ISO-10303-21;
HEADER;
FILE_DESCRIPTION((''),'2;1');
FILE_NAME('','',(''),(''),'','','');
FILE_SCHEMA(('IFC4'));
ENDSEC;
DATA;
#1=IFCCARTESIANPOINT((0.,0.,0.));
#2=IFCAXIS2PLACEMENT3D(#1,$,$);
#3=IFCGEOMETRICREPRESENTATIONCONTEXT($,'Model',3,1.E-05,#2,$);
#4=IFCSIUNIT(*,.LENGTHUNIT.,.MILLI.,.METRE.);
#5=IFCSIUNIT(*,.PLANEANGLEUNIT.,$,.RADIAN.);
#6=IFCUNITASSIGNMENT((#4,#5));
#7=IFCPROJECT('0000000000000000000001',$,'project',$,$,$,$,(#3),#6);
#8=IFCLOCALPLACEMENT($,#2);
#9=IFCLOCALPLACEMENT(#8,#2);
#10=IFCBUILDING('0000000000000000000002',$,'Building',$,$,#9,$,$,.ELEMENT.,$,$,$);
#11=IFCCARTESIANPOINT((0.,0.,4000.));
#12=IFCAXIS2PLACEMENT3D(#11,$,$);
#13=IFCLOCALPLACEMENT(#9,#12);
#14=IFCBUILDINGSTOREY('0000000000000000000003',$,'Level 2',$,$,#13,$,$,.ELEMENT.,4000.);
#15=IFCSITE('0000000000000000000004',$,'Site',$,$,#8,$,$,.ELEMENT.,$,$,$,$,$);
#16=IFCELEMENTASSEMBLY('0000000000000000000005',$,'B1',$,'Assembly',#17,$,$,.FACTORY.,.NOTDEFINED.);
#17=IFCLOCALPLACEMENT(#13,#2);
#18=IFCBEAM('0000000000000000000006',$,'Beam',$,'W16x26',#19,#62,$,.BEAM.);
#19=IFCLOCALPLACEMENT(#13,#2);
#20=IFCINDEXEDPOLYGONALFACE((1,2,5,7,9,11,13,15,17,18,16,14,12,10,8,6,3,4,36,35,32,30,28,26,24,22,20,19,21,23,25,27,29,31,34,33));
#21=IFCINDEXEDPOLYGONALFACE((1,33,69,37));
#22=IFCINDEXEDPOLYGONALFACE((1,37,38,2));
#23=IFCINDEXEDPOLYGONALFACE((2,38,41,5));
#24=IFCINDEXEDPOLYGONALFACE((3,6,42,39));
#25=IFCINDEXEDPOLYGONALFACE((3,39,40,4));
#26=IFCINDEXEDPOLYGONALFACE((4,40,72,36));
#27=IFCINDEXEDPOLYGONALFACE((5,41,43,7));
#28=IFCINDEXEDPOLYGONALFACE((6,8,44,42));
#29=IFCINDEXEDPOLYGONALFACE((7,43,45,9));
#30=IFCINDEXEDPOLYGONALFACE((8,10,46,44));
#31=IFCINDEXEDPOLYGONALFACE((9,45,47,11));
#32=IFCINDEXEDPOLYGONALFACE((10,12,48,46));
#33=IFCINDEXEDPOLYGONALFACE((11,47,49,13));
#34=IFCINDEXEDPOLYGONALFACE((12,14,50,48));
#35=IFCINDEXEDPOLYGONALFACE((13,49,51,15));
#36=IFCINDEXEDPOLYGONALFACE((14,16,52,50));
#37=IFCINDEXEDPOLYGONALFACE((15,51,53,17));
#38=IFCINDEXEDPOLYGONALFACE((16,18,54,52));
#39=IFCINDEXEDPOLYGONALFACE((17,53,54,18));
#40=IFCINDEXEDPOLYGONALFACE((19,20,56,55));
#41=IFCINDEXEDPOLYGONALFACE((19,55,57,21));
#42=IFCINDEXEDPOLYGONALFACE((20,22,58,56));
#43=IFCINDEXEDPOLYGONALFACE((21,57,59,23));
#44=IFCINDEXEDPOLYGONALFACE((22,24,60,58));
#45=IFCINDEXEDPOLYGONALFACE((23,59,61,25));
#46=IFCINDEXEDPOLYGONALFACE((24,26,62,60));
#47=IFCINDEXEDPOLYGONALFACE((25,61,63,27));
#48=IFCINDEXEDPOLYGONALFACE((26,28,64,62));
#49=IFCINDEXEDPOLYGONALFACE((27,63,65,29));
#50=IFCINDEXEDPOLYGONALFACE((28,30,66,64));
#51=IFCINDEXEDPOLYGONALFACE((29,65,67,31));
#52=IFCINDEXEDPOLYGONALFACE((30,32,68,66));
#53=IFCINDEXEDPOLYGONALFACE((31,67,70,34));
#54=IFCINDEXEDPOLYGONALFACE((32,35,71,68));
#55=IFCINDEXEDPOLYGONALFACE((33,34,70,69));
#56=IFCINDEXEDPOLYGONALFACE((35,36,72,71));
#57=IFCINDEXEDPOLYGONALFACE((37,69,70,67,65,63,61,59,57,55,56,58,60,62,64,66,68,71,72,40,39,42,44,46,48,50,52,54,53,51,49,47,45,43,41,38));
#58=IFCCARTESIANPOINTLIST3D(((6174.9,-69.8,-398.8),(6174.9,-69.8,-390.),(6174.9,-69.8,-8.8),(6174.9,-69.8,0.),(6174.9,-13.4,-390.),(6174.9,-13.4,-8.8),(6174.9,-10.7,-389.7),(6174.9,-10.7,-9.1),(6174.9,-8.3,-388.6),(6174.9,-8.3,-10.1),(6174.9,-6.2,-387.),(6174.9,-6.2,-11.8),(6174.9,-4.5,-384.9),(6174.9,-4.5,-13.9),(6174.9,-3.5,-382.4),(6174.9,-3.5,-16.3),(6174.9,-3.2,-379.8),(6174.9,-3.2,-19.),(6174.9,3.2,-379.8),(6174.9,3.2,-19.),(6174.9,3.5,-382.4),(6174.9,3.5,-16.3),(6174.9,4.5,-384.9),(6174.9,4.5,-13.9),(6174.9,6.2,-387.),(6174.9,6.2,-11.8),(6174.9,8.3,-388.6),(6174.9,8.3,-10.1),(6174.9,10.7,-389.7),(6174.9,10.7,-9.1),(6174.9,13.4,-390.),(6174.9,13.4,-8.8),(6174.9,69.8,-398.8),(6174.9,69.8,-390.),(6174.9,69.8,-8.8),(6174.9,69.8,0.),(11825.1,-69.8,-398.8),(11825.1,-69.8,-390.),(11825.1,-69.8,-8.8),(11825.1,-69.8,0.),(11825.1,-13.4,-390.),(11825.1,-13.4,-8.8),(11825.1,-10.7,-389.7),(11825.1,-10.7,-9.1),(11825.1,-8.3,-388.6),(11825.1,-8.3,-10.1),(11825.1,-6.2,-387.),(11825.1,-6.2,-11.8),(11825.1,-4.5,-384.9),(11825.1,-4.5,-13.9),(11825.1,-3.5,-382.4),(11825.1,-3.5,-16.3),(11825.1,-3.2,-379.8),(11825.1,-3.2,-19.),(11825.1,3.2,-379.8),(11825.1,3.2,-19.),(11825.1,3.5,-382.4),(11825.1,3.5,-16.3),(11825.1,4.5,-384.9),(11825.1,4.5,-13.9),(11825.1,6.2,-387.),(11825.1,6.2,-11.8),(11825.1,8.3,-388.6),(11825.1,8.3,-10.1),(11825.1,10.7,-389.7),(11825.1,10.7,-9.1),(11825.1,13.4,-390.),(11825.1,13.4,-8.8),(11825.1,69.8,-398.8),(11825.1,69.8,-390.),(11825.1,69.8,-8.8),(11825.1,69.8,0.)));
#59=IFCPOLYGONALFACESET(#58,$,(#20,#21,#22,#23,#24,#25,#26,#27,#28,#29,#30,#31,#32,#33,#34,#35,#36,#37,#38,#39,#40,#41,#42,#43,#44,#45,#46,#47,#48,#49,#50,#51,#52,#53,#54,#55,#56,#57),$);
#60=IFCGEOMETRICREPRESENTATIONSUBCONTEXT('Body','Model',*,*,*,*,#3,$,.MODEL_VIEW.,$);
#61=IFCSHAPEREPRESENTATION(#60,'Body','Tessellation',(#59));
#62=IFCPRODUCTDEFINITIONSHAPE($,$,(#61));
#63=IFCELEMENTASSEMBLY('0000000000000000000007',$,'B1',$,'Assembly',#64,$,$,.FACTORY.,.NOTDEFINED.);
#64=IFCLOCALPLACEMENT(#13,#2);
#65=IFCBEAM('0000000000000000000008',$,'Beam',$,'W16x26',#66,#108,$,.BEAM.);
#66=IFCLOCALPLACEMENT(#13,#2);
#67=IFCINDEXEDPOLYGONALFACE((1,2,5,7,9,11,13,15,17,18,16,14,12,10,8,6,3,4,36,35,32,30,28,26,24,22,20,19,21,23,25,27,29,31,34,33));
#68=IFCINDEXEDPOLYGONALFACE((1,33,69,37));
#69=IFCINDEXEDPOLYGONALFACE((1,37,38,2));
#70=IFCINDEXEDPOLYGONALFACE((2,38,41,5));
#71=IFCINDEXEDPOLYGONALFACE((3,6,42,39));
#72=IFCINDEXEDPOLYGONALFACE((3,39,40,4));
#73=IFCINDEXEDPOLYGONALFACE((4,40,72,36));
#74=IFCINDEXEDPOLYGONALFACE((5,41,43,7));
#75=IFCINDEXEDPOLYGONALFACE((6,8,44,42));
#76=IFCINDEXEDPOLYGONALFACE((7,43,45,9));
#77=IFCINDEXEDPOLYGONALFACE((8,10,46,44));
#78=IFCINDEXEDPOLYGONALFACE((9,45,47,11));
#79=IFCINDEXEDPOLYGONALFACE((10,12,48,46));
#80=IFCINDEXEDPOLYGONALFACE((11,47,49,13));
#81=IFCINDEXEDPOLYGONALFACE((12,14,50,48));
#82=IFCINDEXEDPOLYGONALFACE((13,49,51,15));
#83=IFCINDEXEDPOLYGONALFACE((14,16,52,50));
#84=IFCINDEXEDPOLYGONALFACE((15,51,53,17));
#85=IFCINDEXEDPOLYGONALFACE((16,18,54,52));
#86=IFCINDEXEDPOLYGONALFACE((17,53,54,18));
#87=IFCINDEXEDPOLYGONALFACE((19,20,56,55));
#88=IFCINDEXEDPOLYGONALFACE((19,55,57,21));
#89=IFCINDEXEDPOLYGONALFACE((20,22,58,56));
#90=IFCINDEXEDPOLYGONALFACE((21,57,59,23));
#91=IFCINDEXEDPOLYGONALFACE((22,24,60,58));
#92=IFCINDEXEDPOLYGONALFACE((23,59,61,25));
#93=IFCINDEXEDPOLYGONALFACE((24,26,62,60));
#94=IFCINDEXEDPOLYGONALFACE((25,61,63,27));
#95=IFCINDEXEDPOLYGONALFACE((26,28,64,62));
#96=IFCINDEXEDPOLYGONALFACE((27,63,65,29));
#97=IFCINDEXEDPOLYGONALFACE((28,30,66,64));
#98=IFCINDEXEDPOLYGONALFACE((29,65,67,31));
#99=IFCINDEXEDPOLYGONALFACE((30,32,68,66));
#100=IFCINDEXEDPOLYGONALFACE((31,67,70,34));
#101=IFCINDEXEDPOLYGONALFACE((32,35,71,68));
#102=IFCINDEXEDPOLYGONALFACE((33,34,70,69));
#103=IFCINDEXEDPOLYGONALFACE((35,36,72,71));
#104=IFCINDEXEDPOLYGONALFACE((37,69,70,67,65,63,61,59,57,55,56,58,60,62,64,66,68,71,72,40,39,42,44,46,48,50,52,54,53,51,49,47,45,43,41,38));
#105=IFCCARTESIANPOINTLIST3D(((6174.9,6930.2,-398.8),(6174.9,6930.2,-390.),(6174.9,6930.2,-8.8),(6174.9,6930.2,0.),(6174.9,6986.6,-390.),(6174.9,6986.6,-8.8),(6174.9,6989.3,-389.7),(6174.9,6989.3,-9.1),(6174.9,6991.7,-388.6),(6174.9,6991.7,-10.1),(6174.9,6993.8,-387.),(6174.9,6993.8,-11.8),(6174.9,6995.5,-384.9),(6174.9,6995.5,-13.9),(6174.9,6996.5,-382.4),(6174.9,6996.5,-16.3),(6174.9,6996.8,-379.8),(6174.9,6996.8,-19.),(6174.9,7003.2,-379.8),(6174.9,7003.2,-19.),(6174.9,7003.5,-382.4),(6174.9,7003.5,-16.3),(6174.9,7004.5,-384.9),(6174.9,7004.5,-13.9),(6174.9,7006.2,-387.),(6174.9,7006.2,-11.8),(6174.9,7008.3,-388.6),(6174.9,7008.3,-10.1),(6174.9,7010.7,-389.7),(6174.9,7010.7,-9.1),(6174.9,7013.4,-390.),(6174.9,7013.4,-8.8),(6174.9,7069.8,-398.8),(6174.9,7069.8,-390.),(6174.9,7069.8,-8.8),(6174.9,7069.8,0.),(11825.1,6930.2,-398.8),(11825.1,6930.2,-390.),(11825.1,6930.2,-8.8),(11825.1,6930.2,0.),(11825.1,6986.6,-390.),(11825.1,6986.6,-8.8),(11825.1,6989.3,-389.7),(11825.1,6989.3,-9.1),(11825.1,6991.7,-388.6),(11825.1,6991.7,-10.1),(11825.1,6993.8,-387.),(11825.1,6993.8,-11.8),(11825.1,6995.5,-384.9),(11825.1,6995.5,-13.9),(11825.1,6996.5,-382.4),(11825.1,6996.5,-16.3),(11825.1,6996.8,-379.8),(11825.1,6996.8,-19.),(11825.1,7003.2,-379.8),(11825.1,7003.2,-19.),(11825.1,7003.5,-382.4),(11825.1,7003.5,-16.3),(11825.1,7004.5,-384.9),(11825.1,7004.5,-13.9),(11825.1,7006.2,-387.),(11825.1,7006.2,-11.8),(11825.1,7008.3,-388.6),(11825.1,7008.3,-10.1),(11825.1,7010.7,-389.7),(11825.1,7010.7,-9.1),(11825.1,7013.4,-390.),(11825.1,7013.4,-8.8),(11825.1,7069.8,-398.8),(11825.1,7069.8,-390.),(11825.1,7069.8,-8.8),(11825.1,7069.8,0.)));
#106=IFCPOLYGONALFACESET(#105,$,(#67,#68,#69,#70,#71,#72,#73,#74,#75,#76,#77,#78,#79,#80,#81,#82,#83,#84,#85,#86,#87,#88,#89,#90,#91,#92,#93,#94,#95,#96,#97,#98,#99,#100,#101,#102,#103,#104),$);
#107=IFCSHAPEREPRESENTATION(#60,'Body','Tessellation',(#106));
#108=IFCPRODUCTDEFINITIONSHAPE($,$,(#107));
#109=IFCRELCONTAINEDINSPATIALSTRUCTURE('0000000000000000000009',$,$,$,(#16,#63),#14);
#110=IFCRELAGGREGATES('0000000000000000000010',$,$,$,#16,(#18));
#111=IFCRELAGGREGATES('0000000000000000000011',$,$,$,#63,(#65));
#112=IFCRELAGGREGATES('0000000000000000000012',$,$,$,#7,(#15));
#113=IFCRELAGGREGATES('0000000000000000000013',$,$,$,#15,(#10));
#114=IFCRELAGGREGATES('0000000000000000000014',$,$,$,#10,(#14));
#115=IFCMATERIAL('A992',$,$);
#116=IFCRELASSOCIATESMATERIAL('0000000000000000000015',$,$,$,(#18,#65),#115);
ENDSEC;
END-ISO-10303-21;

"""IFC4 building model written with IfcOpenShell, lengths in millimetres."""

from ifc_helpers import new_model, si_unit, frame, frame_2d, origin, place, context, subcontext, project, spatial, i_section, extrude, material, element, aggregate, save


model = new_model("IFC4")

# Units and contexts
model_context = context("Model", 3, precision=1e-05, world=origin())
body_context = subcontext(model_context, "Body", "Model", "MODEL_VIEW")
ifc_project = project(units=[si_unit("LENGTHUNIT", "METRE", prefix="MILLI"), si_unit("PLANEANGLEUNIT", "RADIAN")], contexts=[model_context])

# Site, building, storey
site_placement = place(None, origin())
site = spatial("IfcSite", under=ifc_project, at=site_placement, Name="Site", CompositionType="ELEMENT")
building_placement = place(site_placement, origin())
building = spatial("IfcBuilding", under=site, at=building_placement, Name="Building", CompositionType="ELEMENT")
storey_placement = place(building_placement, frame((0.0, 0.0, 4000.0)))
storey = spatial("IfcBuildingStorey", under=building, at=storey_placement, Name="Level 2", CompositionType="ELEMENT", Elevation=4000.0)

# Element assemblies, beams
assembly_1_placement = place(storey_placement, origin())
assembly_1 = element("IfcElementAssembly", 1, at=assembly_1_placement, inside=storey, Name="B1", ObjectType="Assembly", AssemblyPlace="FACTORY", PredefinedType="NOTDEFINED")
ifc_material_1 = material(Name="A992")
beam_1_placement = place(storey_placement, frame((6174.9, 0.0, 0.0), z_axis=(1.0, 0.0, 0.0), x_axis=(0.0, 1.0, 0.0)))
beam_1 = element("IfcBeam", 2, at=beam_1_placement, material=ifc_material_1, Name="Beam", ObjectType="W16x26", PredefinedType="BEAM", context=body_context, shape_type="SweptSolid", body=[
    extrude(i_section(OverallWidth=139.7, OverallDepth=398.8, WebThickness=6.3, FlangeThickness=8.8, FilletRadius=10.2, at=frame_2d((0.0, -199.4))), origin(), (0.0, 0.0, 1.0), 5650.1),
])
assembly_2_placement = place(storey_placement, origin())
assembly_2 = element("IfcElementAssembly", 3, at=assembly_2_placement, inside=storey, Name="B1", ObjectType="Assembly", AssemblyPlace="FACTORY", PredefinedType="NOTDEFINED")
beam_2_placement = place(storey_placement, frame((6174.9, 7000.0, 0.0), z_axis=(1.0, 0.0, 0.0), x_axis=(0.0, 1.0, 0.0)))
beam_2 = element("IfcBeam", 4, at=beam_2_placement, material=ifc_material_1, Name="Beam", ObjectType="W16x26", PredefinedType="BEAM", context=body_context, shape_type="SweptSolid", body=[
    extrude(i_section(OverallWidth=139.7, OverallDepth=398.8, WebThickness=6.3, FlangeThickness=8.8, FilletRadius=10.2, at=frame_2d((0.0, -199.4))), origin(), (0.0, 0.0, 1.0), 5650.1),
])

aggregate(assembly_1, [beam_1])
aggregate(assembly_2, [beam_2])

save(model, "model.ifc")
